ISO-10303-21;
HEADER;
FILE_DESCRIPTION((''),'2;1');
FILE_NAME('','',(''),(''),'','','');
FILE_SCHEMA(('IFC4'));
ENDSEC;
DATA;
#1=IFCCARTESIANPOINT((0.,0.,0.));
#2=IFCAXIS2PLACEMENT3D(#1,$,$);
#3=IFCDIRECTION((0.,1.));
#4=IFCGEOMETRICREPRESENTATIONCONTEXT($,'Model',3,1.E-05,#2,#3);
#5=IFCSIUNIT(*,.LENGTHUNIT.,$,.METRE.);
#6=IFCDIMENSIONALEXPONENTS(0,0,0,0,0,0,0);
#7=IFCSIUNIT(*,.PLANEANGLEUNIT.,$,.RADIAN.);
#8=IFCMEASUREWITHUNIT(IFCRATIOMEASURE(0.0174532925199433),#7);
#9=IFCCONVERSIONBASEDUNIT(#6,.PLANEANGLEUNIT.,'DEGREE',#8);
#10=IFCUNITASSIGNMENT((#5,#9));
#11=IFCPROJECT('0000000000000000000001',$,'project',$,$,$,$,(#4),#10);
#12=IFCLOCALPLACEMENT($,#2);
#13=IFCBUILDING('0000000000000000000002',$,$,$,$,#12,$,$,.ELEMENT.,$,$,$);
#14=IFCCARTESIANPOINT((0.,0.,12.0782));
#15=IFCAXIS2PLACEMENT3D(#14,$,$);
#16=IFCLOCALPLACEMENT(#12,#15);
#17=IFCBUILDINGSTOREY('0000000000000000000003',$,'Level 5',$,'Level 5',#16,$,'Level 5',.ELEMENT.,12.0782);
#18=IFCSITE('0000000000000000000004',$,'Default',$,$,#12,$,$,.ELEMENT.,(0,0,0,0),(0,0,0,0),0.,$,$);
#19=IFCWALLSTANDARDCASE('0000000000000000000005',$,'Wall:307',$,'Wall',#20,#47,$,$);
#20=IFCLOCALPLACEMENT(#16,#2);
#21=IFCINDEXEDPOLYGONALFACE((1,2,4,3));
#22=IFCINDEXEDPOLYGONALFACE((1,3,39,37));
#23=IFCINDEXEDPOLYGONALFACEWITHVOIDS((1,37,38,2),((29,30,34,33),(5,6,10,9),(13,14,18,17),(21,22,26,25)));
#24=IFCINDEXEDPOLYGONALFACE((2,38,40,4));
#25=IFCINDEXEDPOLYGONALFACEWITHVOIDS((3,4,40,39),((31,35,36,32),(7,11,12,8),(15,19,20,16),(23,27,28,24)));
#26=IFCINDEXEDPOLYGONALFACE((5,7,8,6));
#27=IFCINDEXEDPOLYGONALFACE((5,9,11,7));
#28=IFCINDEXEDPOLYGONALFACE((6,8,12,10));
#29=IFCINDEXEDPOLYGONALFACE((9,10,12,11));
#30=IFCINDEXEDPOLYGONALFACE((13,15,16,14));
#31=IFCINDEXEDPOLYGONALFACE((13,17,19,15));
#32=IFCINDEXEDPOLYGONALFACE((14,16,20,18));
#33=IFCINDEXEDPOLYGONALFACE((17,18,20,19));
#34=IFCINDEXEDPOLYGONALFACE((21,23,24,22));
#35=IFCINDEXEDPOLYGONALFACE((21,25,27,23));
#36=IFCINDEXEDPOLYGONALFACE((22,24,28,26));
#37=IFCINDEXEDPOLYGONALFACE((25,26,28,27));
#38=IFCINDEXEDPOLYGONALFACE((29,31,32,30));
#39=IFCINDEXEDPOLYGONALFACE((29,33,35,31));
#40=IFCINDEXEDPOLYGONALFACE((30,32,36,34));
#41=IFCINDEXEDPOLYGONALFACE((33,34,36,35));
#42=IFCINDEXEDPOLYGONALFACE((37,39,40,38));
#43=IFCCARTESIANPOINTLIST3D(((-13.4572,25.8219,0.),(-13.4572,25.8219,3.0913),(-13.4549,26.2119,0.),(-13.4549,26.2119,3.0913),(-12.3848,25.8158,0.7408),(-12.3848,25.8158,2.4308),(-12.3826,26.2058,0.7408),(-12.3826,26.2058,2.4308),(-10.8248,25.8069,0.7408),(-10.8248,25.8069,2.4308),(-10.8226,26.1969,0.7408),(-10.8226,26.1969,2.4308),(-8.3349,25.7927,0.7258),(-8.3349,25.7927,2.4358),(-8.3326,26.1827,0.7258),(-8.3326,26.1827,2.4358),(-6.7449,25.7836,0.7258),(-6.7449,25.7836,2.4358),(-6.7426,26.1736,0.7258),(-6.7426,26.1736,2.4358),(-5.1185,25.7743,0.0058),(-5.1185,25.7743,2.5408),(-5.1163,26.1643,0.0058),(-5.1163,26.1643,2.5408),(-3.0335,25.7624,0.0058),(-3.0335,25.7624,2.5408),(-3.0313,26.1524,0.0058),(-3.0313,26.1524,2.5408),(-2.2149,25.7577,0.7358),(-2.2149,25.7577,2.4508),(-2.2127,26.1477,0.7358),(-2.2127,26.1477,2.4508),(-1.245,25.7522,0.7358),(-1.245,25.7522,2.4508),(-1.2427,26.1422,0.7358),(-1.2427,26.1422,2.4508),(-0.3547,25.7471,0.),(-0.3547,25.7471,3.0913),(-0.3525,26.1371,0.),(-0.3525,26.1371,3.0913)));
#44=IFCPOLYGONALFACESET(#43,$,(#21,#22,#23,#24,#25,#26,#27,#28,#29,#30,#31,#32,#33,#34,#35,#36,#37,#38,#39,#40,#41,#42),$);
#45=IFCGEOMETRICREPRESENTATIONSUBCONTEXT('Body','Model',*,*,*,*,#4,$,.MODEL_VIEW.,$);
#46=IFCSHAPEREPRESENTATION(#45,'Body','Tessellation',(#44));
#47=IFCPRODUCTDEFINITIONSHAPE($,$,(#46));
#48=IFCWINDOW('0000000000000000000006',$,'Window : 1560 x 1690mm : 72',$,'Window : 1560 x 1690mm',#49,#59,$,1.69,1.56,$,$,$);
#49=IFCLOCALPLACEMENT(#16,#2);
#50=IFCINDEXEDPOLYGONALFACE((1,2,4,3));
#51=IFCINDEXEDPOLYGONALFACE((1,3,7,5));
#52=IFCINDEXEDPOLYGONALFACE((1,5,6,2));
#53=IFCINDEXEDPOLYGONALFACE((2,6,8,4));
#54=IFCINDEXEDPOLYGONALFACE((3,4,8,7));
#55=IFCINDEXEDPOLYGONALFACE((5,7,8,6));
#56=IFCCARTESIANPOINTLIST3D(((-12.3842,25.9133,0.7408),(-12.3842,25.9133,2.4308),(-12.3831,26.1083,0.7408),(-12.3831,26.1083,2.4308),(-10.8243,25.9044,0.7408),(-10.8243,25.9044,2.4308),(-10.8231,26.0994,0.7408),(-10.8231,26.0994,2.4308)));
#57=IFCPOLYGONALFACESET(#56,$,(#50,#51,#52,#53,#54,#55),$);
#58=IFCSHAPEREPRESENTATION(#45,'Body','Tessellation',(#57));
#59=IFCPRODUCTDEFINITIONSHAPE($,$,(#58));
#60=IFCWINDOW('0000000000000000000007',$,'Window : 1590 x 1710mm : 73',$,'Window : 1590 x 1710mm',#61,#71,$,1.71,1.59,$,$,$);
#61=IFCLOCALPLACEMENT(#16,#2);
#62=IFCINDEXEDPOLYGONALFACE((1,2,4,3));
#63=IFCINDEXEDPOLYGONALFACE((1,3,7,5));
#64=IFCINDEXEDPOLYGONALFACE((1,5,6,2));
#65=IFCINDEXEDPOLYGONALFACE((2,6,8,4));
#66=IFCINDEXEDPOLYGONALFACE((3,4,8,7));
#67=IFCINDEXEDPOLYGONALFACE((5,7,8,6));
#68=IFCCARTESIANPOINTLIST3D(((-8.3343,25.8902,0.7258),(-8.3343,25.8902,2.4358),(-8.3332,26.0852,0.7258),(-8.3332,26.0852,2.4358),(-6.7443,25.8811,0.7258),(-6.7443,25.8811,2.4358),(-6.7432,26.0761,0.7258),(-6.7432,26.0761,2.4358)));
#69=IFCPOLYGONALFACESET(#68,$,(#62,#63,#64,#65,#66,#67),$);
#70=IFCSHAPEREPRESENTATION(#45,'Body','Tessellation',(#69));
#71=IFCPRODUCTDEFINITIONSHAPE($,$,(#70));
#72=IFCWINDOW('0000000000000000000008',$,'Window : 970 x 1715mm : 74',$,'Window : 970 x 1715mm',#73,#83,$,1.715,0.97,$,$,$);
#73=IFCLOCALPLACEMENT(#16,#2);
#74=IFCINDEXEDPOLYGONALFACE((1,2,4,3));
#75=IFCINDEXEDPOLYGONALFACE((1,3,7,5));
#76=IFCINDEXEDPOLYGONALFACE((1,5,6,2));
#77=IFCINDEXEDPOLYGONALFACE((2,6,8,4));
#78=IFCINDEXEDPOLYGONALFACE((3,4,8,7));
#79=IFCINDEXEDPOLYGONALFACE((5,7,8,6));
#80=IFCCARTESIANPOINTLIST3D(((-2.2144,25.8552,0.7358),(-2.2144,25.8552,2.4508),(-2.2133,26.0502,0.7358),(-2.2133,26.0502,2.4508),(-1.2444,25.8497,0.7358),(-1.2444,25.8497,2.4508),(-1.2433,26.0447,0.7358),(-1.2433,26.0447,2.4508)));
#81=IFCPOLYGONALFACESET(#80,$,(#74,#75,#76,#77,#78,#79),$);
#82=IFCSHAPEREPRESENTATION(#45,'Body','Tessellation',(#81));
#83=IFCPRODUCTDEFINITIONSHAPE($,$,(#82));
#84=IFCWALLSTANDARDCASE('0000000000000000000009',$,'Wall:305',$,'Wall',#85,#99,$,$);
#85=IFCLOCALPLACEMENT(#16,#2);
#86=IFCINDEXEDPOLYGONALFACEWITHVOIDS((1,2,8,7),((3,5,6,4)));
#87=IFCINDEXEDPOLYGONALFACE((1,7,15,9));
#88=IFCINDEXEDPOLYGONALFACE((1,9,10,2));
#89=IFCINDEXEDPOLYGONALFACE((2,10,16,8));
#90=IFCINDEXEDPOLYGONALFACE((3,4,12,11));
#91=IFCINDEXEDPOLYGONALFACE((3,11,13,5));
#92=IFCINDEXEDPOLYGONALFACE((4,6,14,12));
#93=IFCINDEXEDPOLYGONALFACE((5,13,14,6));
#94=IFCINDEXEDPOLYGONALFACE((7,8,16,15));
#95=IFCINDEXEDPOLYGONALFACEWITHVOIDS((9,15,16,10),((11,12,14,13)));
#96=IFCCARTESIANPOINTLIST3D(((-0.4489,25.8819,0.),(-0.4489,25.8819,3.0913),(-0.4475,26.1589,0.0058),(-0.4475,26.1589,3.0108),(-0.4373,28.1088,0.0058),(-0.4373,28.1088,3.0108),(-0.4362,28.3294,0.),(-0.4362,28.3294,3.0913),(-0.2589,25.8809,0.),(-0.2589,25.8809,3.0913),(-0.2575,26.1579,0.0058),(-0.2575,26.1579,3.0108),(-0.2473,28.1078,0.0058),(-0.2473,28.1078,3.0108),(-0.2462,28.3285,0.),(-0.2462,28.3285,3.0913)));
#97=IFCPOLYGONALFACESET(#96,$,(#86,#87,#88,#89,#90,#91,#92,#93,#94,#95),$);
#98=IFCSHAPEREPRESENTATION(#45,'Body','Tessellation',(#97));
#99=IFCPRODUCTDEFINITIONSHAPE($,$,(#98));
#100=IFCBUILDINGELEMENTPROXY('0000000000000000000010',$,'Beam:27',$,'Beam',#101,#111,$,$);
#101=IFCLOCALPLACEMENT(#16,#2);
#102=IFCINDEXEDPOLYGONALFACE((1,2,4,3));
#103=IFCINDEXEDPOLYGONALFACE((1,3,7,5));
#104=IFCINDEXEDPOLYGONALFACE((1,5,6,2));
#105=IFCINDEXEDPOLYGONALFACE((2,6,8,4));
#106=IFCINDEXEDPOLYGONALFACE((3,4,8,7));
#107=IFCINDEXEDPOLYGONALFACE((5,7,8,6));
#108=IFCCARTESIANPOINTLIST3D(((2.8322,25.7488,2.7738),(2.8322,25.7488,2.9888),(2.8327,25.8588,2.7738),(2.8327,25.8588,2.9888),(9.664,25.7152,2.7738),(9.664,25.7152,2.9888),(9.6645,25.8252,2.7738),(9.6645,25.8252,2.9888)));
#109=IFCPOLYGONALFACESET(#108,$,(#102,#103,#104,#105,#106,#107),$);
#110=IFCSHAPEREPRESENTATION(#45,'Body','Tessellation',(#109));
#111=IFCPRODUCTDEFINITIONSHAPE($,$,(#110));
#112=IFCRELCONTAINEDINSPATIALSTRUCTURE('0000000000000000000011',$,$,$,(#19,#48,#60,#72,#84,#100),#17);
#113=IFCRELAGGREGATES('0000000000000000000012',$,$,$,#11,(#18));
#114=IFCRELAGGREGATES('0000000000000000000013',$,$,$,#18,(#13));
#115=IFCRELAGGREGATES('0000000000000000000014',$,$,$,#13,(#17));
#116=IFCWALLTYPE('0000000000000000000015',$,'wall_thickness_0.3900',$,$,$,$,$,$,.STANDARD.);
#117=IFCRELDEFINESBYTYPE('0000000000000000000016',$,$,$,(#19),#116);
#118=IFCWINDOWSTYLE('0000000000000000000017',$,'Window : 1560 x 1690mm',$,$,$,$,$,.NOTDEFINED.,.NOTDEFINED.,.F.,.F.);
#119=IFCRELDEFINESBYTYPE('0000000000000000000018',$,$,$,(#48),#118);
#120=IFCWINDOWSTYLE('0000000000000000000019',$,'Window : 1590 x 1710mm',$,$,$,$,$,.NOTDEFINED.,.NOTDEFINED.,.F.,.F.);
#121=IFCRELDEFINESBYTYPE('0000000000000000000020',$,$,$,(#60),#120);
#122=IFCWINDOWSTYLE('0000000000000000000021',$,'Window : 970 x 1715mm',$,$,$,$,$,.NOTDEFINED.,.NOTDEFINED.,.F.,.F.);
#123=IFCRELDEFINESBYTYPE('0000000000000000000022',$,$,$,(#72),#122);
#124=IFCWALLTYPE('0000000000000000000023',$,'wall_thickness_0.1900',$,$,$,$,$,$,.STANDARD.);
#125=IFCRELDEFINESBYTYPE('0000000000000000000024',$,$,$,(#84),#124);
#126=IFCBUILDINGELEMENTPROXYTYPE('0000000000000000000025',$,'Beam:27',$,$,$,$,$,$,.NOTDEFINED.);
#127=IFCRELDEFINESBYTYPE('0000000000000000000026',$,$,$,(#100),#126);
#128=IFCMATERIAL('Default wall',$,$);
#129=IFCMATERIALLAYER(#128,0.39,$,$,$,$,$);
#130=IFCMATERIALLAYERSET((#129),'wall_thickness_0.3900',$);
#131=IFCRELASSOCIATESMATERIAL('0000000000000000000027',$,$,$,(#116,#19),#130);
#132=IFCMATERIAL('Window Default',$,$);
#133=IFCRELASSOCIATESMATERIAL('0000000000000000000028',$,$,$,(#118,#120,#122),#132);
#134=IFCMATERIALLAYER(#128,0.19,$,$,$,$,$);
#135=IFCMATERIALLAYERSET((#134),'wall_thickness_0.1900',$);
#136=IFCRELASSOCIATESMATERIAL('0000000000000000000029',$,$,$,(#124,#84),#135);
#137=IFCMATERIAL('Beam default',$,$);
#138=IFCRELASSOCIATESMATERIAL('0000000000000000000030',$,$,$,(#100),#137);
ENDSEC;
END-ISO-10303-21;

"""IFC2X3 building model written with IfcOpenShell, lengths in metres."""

from ifc_helpers import new_model, entity, si_unit, converted_unit, direction, frame, frame_2d, origin, origin_2d_with_axis, place, context, subcontext, project, spatial, polyline, rectangle, outline, extrude, clip, halfspace, source, transform, mapped, material, layer, layer_set, layer_usage, type_object, type_shapes, element, fill, save


model = new_model("IFC2X3")

# Units and contexts
model_context = context("Model", 3, precision=1e-05, world=origin(), true_north=direction((0.0, 1.0)))
body_context = subcontext(model_context, "Body", "Model", "MODEL_VIEW")
ifc_project = project(units=[si_unit("LENGTHUNIT", "METRE"), converted_unit("PLANEANGLEUNIT", "DEGREE", entity("IfcRatioMeasure", 0.0174532925199433), si_unit("PLANEANGLEUNIT", "RADIAN"), dimensions=[0, 0, 0, 0, 0, 0, 0])], contexts=[model_context])

# Site, building, storey
placement_1 = place(None, origin())
site = spatial("IfcSite", under=ifc_project, at=placement_1, Name="Default", CompositionType="ELEMENT", RefLatitude=(0, 0, 0, 0), RefLongitude=(0, 0, 0, 0), RefElevation=0.0)
building = spatial("IfcBuilding", under=site, at=placement_1, CompositionType="ELEMENT")
storey_placement = place(placement_1, frame((0.0, 0.0, 12.0782)))
storey = spatial("IfcBuildingStorey", under=building, at=storey_placement, Name="Level 5", ObjectType="Level 5", LongName="Level 5", CompositionType="ELEMENT", Elevation=12.0782)

# Shared definitions
ifc_material_1 = material(Name="Default wall")
ifc_material_2 = material(Name="Window Default")

# Wall, openings, windows
ifc_layer_1 = layer(ifc_material_1, 0.39)
ifc_layer_set_1 = layer_set([ifc_layer_1], Name="wall_thickness_0.3900")
ifc_layer_usage_1 = layer_usage(ifc_layer_set_1, "AXIS2", "POSITIVE", -0.195)
wall_type_1 = type_object("IfcWallType", Name="wall_thickness_0.3900", PredefinedType="STANDARD", material=ifc_layer_set_1)
wall_1_placement = place(storey_placement, frame((-13.456, 26.0169, 0.0), z_axis=(0.0, 0.0, 1.0), x_axis=(0.999984, -0.00571, 0.0)))
wall_1 = element("IfcWallStandardCase", 1, at=wall_1_placement, inside=storey, type_object=wall_type_1, material=ifc_layer_usage_1, Name="Wall:307", ObjectType="Wall", context=body_context, shape_type="Clipping", body=[
    clip(extrude(outline(polyline([(13.1026, -0.195), (13.1026, 0.195), (0.0, 0.195), (0.0, -0.195), (13.1026, -0.195)])), origin(), (0.0, 0.0, 1.0), 3.0913), halfspace(frame((37.874, -6.5645, 9.0815), z_axis=(0.001128, 0.389103, 0.921193), x_axis=(-0.999991, 0.004108, -0.000511)), False)),
])
opening_1_placement = place(wall_1_placement, frame((8.3388, -0.195, 0.0058)))
element("IfcOpeningElement", 2, at=opening_1_placement, cuts=wall_1, ObjectType="Opening", context=body_context, shape_type="SweptSolid", body=[
    extrude(rectangle(XDim=2.085, YDim=2.535, at=frame_2d((1.2675, 1.0425), x_axis=(0.0, 1.0))), frame((0.0, 0.0, 0.0), z_axis=(0.0, 1.0, 0.0), x_axis=(0.0, 0.0, 1.0)), (0.0, 0.0, 1.0), 0.39),
])
opening_2_placement = place(wall_1_placement, frame((1.0724, -0.195, 0.7408)))
opening_2 = element("IfcOpeningElement", 3, at=opening_2_placement, cuts=wall_1, ObjectType="Opening", context=body_context, shape_type="SweptSolid", body=[
    extrude(rectangle(XDim=1.56, YDim=1.69, at=frame_2d((0.845, 0.78), x_axis=(0.0, 1.0))), frame((0.0, 0.0, 0.0), z_axis=(0.0, 1.0, 0.0), x_axis=(0.0, 0.0, 1.0)), (0.0, 0.0, 1.0), 0.39),
])
opening_3_placement = place(wall_1_placement, frame((5.1224, -0.195, 0.7258)))
opening_3 = element("IfcOpeningElement", 4, at=opening_3_placement, cuts=wall_1, ObjectType="Opening", context=body_context, shape_type="SweptSolid", body=[
    extrude(rectangle(XDim=1.59, YDim=1.71, at=frame_2d((0.855, 0.795), x_axis=(0.0, 1.0))), frame((0.0, 0.0, 0.0), z_axis=(0.0, 1.0, 0.0), x_axis=(0.0, 0.0, 1.0)), (0.0, 0.0, 1.0), 0.39),
])
opening_4_placement = place(wall_1_placement, frame((11.2424, -0.195, 0.7358)))
opening_4 = element("IfcOpeningElement", 5, at=opening_4_placement, cuts=wall_1, ObjectType="Opening", context=body_context, shape_type="SweptSolid", body=[
    extrude(rectangle(XDim=0.97, YDim=1.715, at=frame_2d((0.8575, 0.485), x_axis=(0.0, 1.0))), frame((0.0, 0.0, 0.0), z_axis=(0.0, 1.0, 0.0), x_axis=(0.0, 0.0, 1.0)), (0.0, 0.0, 1.0), 0.39),
])
window_style_1 = type_object("IfcWindowStyle", Name="Window : 1560 x 1690mm", ConstructionType="NOTDEFINED", OperationType="NOTDEFINED", ParameterTakesPrecedence=False, Sizeable=False, material=ifc_material_2)
shared_shape_1 = source(origin(), body_context, "Body", "SweptSolid", [
    extrude(rectangle(XDim=0.195, YDim=1.56, at=origin_2d_with_axis()), frame((0.78, 0.195, 0.0), z_axis=(0.0, 0.0, 1.0), x_axis=(0.0, 1.0, 0.0)), (0.0, 0.0, 1.0), 1.69),
])
type_shapes(window_style_1, [shared_shape_1])
window_1_placement = place(opening_2_placement, origin())
window_1 = element("IfcWindow", 6, at=window_1_placement, inside=storey, type_object=window_style_1, Name="Window : 1560 x 1690mm : 72", ObjectType="Window : 1560 x 1690mm", OverallHeight=1.69, OverallWidth=1.56, context=body_context, shape_type="MappedRepresentation", body=[
    mapped(shared_shape_1, transform((0.0, 0.0, 0.0), scale=1.0)),
])
fill(opening_2, window_1)
window_style_2 = type_object("IfcWindowStyle", Name="Window : 1590 x 1710mm", ConstructionType="NOTDEFINED", OperationType="NOTDEFINED", ParameterTakesPrecedence=False, Sizeable=False, material=ifc_material_2)
shared_shape_2 = source(origin(), body_context, "Body", "SweptSolid", [
    extrude(rectangle(XDim=0.195, YDim=1.59, at=origin_2d_with_axis()), frame((0.795, 0.195, 0.0), z_axis=(0.0, 0.0, 1.0), x_axis=(0.0, 1.0, 0.0)), (0.0, 0.0, 1.0), 1.71),
])
type_shapes(window_style_2, [shared_shape_2])
window_2_placement = place(opening_3_placement, origin())
window_2 = element("IfcWindow", 7, at=window_2_placement, inside=storey, type_object=window_style_2, Name="Window : 1590 x 1710mm : 73", ObjectType="Window : 1590 x 1710mm", OverallHeight=1.71, OverallWidth=1.59, context=body_context, shape_type="MappedRepresentation", body=[
    mapped(shared_shape_2, transform((0.0, 0.0, 0.0), scale=1.0)),
])
fill(opening_3, window_2)
window_style_3 = type_object("IfcWindowStyle", Name="Window : 970 x 1715mm", ConstructionType="NOTDEFINED", OperationType="NOTDEFINED", ParameterTakesPrecedence=False, Sizeable=False, material=ifc_material_2)
shared_shape_3 = source(origin(), body_context, "Body", "SweptSolid", [
    extrude(rectangle(XDim=0.195, YDim=0.97, at=origin_2d_with_axis()), frame((0.485, 0.195, 0.0), z_axis=(0.0, 0.0, 1.0), x_axis=(0.0, 1.0, 0.0)), (0.0, 0.0, 1.0), 1.715),
])
type_shapes(window_style_3, [shared_shape_3])
window_3_placement = place(opening_4_placement, origin())
window_3 = element("IfcWindow", 8, at=window_3_placement, inside=storey, type_object=window_style_3, Name="Window : 970 x 1715mm : 74", ObjectType="Window : 970 x 1715mm", OverallHeight=1.715, OverallWidth=0.97, context=body_context, shape_type="MappedRepresentation", body=[
    mapped(shared_shape_3, transform((0.0, 0.0, 0.0), scale=1.0)),
])
fill(opening_4, window_3)

# Wall, opening
ifc_layer_2 = layer(ifc_material_1, 0.19)
ifc_layer_set_2 = layer_set([ifc_layer_2], Name="wall_thickness_0.1900")
ifc_layer_usage_2 = layer_usage(ifc_layer_set_2, "AXIS2", "POSITIVE", -0.095)
wall_type_2 = type_object("IfcWallType", Name="wall_thickness_0.1900", PredefinedType="STANDARD", material=ifc_layer_set_2)
wall_2_placement = place(storey_placement, frame((-0.3412, 28.329, 0.0), z_axis=(0.0, 0.0, 1.0), x_axis=(-0.005204, -0.999986, 0.0)))
wall_2 = element("IfcWallStandardCase", 9, at=wall_2_placement, inside=storey, type_object=wall_type_2, material=ifc_layer_usage_2, Name="Wall:305", ObjectType="Wall", context=body_context, shape_type="Clipping", body=[
    clip(extrude(outline(polyline([(2.4476, -0.095), (2.4476, 0.095), (0.0, 0.095), (0.0, -0.095), (2.4476, -0.095)])), origin(), (0.0, 0.0, 1.0), 3.0913), halfspace(frame((-47.5135, -1.1327, 4.0083), z_axis=(0.000614, -0.389903, 0.920856), x_axis=(0.000761, 0.920855, 0.389905)), False)),
])
opening_5_placement = place(wall_2_placement, frame((0.2206, -0.095, 0.0058)))
element("IfcOpeningElement", 10, at=opening_5_placement, cuts=wall_2, ObjectType="Opening", context=body_context, shape_type="SweptSolid", body=[
    extrude(rectangle(XDim=1.95, YDim=3.005, at=frame_2d((1.5025, 0.975), x_axis=(0.0, 1.0))), frame((0.0, 0.0, 0.0), z_axis=(0.0, 1.0, 0.0), x_axis=(0.0, 0.0, 1.0)), (0.0, 0.0, 1.0), 0.19),
])

# Building element proxy
ifc_material_3 = material(Name="Beam default")
building_element_proxy_type = type_object("IfcBuildingElementProxyType", Name="Beam:27", PredefinedType="NOTDEFINED")
shared_shape_4 = source(origin(), body_context, "Body", "SweptSolid", [
    extrude(outline(polyline([(6.8319, -0.055), (6.8319, 0.055), (0.0, 0.055), (0.0, -0.055), (6.8319, -0.055)])), origin(), (0.0, 0.0, 1.0), 0.215),
])
type_shapes(building_element_proxy_type, [shared_shape_4])
placement_2 = place(placement_1, frame((0.0, 0.0, 14.852)))
proxy_placement = place(placement_2, frame((2.8325, 25.8038, 0.0), z_axis=(0.0, 0.0, 1.0), x_axis=(0.999988, -0.004918, 0.0)))
element("IfcBuildingElementProxy", 11, at=proxy_placement, inside=storey, type_object=building_element_proxy_type, material=ifc_material_3, Name="Beam:27", ObjectType="Beam", context=body_context, shape_type="MappedRepresentation", body=[
    mapped(shared_shape_4, transform((0.0, 0.0, 0.0), scale=1.0)),
])

save(model, "model.ifc")
